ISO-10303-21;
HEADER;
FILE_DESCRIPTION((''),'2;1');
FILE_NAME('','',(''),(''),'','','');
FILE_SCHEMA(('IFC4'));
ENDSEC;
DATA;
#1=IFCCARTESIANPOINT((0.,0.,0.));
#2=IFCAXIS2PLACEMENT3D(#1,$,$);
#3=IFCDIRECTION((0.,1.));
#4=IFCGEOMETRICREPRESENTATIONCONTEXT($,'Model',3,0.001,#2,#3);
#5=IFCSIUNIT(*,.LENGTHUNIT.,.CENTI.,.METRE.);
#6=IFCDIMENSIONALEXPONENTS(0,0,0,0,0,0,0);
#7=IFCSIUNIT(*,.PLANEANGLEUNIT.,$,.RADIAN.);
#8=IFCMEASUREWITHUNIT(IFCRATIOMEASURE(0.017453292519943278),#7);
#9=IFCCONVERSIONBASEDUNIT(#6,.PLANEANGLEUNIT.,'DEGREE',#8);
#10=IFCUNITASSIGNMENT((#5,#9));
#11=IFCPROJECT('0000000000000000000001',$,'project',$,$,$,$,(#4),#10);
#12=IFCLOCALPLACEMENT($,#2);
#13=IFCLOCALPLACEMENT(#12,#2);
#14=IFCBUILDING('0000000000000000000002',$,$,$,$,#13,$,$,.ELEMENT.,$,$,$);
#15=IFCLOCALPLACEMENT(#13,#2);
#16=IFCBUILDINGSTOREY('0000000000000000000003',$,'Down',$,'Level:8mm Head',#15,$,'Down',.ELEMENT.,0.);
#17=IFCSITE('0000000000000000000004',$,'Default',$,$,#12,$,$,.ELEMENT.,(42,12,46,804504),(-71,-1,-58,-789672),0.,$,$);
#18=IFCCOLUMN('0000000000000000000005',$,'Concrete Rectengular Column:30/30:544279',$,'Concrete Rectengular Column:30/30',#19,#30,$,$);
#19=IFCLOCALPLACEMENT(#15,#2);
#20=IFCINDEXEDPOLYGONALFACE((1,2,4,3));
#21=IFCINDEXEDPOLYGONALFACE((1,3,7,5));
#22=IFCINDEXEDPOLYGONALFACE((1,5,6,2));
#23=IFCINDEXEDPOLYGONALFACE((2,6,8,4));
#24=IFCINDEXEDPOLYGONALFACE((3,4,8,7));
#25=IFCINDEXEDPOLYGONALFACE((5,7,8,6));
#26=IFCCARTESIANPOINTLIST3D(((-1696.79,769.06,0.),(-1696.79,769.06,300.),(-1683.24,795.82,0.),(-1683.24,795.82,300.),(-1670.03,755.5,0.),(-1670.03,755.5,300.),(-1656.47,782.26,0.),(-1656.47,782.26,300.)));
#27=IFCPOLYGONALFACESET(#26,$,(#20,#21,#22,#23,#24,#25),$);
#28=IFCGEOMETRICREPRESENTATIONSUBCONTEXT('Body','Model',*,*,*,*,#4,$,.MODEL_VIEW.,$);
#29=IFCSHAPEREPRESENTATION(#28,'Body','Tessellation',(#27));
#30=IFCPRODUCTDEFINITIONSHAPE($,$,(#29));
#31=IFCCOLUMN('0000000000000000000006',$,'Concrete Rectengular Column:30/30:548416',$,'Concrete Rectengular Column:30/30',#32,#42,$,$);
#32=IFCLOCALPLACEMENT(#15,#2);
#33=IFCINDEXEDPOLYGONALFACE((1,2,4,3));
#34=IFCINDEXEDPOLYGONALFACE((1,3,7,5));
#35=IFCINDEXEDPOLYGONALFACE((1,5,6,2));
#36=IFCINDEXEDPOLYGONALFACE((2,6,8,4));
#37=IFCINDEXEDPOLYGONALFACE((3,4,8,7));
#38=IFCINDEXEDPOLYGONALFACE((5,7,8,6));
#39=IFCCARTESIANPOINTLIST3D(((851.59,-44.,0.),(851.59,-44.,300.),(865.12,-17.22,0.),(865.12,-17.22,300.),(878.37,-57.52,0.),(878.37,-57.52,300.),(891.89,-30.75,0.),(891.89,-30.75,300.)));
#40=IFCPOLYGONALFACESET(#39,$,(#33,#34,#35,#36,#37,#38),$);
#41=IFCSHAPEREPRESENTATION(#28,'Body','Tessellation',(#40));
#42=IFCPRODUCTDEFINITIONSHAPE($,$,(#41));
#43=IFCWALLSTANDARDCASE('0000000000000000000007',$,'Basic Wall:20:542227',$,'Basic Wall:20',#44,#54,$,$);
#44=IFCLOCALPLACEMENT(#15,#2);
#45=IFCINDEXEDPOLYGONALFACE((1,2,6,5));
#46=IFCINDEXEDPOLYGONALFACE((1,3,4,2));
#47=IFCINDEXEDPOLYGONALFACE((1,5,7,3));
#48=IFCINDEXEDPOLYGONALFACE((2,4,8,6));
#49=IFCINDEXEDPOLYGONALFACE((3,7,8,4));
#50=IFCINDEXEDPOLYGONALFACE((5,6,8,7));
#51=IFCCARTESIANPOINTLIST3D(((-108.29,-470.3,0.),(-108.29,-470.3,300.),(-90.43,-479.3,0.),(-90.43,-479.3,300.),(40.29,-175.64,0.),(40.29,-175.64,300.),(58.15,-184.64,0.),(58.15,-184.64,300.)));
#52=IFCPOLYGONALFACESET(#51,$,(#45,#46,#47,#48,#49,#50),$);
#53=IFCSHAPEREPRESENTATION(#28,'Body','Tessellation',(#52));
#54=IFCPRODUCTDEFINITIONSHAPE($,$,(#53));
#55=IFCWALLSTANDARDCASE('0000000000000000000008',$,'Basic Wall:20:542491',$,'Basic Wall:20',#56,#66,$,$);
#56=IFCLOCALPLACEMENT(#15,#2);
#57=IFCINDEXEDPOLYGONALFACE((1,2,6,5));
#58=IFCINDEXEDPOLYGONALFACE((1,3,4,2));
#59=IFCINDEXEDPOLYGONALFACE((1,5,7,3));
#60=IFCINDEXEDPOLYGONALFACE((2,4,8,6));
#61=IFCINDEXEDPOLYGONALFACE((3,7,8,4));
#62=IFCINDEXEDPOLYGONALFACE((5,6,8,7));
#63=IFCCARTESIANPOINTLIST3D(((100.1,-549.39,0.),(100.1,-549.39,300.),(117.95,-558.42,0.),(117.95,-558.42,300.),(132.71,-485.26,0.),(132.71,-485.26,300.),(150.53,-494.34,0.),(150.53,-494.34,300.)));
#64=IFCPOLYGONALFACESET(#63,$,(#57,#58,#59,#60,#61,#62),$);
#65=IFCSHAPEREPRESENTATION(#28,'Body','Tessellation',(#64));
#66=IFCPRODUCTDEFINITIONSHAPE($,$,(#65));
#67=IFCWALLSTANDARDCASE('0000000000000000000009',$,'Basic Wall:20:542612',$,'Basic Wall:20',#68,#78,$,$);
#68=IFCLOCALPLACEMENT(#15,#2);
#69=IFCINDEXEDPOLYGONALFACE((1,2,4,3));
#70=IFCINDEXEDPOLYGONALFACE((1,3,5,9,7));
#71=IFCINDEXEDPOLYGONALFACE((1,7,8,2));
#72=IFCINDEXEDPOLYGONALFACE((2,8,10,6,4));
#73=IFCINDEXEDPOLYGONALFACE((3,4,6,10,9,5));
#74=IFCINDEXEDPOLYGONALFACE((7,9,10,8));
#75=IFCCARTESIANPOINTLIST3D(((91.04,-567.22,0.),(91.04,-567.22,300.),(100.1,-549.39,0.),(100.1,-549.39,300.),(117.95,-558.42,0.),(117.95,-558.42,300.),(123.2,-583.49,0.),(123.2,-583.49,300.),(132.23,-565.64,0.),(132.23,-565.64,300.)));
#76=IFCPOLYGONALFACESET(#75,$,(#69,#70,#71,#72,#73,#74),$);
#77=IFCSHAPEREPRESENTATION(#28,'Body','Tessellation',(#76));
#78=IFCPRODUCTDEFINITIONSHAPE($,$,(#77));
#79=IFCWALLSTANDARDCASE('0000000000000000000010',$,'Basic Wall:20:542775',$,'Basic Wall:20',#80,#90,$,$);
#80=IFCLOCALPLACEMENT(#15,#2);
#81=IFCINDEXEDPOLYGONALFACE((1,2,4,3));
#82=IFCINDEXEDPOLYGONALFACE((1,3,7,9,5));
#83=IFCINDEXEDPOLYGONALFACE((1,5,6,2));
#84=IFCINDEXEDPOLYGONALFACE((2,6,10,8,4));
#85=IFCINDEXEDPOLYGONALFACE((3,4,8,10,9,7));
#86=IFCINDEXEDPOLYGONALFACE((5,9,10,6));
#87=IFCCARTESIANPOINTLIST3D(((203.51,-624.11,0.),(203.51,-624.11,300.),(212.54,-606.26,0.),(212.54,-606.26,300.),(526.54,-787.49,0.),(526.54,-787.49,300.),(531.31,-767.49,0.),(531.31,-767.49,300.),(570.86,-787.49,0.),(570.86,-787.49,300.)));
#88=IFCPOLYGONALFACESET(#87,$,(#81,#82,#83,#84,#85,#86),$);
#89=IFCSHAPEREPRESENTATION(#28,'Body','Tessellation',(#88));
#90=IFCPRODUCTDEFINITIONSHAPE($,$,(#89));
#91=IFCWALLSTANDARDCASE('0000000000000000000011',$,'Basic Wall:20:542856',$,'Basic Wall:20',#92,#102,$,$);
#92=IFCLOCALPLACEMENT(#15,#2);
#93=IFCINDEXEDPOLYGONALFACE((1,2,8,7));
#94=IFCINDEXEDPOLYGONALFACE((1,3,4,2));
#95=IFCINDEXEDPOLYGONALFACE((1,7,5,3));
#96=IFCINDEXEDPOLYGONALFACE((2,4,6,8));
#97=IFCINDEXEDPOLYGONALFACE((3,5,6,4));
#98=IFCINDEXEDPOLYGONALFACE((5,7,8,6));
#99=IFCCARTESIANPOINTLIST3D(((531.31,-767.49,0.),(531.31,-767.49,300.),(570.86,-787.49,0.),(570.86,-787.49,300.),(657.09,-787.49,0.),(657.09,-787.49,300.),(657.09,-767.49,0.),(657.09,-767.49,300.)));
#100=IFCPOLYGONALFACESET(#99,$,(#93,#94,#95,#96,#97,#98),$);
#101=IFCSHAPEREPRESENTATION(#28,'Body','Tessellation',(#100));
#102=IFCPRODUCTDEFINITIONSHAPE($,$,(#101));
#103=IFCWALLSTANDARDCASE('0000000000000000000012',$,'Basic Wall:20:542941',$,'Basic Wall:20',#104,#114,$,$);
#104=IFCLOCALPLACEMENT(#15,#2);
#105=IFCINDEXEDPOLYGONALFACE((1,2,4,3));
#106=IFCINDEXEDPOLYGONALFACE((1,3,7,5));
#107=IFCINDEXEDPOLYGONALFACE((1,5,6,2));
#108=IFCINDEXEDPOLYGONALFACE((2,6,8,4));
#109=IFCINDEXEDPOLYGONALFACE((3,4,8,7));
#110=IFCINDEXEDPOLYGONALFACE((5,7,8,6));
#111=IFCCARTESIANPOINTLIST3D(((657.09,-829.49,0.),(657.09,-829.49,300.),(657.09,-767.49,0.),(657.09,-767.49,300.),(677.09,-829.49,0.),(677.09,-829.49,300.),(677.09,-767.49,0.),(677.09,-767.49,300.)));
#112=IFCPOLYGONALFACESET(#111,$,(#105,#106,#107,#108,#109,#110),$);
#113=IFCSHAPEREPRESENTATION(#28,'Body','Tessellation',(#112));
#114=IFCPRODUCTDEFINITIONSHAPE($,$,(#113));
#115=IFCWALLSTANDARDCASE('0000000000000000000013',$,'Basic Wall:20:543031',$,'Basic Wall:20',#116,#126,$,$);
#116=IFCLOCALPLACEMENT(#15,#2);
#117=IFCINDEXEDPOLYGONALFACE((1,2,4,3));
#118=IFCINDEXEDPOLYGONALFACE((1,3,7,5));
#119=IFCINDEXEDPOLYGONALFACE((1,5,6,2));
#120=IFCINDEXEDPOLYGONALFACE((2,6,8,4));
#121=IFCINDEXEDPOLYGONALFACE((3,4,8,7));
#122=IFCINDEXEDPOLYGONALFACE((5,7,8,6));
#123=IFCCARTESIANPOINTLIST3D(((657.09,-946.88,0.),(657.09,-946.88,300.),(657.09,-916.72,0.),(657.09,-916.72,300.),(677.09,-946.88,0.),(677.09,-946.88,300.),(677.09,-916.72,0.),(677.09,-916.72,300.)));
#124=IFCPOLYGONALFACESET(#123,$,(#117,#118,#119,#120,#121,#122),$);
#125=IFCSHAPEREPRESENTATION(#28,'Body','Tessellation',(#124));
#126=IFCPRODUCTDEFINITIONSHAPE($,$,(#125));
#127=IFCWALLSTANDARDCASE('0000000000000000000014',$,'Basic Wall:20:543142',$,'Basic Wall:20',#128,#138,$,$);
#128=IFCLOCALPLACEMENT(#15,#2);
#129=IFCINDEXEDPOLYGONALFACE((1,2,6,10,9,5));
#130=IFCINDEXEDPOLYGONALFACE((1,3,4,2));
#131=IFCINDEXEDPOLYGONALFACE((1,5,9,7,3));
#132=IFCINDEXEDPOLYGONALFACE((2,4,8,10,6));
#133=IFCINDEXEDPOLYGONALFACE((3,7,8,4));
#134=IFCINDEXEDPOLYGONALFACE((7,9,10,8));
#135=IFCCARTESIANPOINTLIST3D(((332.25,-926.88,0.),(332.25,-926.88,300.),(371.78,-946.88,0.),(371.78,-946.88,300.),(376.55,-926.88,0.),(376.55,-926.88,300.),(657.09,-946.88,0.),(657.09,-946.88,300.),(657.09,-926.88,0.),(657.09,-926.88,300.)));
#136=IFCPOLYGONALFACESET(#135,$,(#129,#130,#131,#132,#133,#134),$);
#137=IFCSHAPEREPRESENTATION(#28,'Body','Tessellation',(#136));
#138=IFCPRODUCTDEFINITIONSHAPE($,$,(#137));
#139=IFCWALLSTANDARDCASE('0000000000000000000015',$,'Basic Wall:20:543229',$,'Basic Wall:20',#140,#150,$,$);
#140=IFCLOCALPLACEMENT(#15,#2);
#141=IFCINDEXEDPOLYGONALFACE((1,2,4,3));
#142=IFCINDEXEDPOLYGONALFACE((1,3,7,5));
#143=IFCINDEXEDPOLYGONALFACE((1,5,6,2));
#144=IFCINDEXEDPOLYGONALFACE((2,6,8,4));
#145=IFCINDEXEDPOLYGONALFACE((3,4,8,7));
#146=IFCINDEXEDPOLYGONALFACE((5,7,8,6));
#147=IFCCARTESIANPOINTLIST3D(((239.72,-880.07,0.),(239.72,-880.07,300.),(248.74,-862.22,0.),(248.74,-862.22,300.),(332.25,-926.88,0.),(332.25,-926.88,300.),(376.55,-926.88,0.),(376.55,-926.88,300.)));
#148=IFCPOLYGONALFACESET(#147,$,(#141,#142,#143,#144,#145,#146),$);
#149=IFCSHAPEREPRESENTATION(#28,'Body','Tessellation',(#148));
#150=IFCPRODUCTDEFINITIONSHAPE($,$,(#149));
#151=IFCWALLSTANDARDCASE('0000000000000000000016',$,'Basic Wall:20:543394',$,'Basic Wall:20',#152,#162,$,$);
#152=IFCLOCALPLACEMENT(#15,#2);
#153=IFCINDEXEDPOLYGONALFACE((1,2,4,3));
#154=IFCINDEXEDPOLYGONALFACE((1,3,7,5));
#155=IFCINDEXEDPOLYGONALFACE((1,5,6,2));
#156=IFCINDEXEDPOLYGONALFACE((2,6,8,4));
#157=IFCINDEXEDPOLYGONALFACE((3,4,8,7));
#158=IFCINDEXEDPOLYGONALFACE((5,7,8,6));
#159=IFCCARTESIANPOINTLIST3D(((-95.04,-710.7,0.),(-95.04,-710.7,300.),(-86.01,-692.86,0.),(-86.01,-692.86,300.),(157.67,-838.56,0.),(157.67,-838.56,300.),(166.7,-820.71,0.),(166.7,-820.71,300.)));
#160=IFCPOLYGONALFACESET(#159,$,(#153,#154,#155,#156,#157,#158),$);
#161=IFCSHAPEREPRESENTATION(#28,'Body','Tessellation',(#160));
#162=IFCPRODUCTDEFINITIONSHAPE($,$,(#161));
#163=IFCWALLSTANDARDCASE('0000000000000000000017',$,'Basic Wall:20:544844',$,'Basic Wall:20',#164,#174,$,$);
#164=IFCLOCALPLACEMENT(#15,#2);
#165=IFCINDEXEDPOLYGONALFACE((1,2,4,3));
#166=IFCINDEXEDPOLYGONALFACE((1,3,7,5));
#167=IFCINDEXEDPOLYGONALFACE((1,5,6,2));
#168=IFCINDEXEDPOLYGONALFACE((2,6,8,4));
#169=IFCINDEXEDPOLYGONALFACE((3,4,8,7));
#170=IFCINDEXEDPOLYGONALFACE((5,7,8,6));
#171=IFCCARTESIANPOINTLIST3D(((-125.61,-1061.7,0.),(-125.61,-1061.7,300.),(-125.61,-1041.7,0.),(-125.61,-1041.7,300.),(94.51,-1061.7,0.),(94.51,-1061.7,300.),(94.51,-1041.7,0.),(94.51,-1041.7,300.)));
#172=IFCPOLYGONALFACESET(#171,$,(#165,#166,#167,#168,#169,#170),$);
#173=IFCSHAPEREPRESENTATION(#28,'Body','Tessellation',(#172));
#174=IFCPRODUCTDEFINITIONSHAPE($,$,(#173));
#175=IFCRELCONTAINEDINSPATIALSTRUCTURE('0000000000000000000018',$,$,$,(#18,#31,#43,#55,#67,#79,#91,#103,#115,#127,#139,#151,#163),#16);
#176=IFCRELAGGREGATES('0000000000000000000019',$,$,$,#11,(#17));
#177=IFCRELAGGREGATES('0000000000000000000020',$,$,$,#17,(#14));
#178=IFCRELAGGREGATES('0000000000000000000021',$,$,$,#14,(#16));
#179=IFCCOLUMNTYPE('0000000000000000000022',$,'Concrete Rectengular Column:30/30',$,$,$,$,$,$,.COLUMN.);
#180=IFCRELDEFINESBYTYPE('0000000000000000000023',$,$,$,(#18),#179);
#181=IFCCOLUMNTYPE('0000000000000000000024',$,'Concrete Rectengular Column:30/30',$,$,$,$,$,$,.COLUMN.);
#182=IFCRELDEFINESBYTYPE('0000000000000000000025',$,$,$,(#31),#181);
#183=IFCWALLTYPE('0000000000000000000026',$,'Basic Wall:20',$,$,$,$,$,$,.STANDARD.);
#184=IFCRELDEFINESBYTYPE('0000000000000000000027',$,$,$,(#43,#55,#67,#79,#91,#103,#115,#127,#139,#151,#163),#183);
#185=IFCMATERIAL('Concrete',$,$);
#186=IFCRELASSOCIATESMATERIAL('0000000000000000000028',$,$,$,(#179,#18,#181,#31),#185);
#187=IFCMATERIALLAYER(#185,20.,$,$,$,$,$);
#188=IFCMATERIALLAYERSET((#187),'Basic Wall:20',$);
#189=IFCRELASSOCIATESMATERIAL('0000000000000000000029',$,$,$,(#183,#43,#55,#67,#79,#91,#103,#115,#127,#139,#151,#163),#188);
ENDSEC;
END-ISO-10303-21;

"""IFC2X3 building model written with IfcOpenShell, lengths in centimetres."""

from ifc_helpers import new_model, entity, si_unit, converted_unit, direction, frame, frame_2d, origin, origin_2d_with_axis, place, context, subcontext, project, spatial, polyline, rectangle, outline, extrude, source, transform, mapped, material, layer, layer_set, layer_usage, type_object, type_shapes, element, save


model = new_model("IFC2X3")

# Units and contexts
model_context = context("Model", 3, precision=0.001, world=origin(), true_north=direction((0.0, 1.0)))
body_context = subcontext(model_context, "Body", "Model", "MODEL_VIEW")
ifc_project = project(units=[si_unit("LENGTHUNIT", "METRE", prefix="CENTI"), converted_unit("PLANEANGLEUNIT", "DEGREE", entity("IfcRatioMeasure", 0.017453292519943278), si_unit("PLANEANGLEUNIT", "RADIAN"), dimensions=[0, 0, 0, 0, 0, 0, 0])], contexts=[model_context])

# Site, building, storey
site_placement = place(None, origin())
site = spatial("IfcSite", under=ifc_project, at=site_placement, Name="Default", CompositionType="ELEMENT", RefLatitude=(42, 12, 46, 804504), RefLongitude=(-71, -1, -58, -789672), RefElevation=0.0)
building_placement = place(site_placement, origin())
building = spatial("IfcBuilding", under=site, at=building_placement, CompositionType="ELEMENT")
storey_placement = place(building_placement, origin())
storey = spatial("IfcBuildingStorey", under=building, at=storey_placement, Name="Down", ObjectType="Level:8mm Head", LongName="Down", CompositionType="ELEMENT", Elevation=0.0)

# Columns
ifc_material = material(Name="Concrete")
column_type_1 = type_object("IfcColumnType", Name="Concrete Rectengular Column:30/30", PredefinedType="COLUMN", material=ifc_material)
shared_shape_1 = source(origin(), body_context, "Body", "SweptSolid", [
    extrude(rectangle(XDim=30.0, YDim=30.0, at=origin_2d_with_axis()), frame((-1676.63, 775.66, 0.0), z_axis=(0.0, 0.0, 1.0), x_axis=(0.451903, 0.892067, 0.0)), (0.0, 0.0, 1.0), 300.0),
])
type_shapes(column_type_1, [shared_shape_1])
column_1_placement = place(storey_placement, origin())
element("IfcColumn", 1, at=column_1_placement, inside=storey, type_object=column_type_1, material=ifc_material, Name="Concrete Rectengular Column:30/30:544279", ObjectType="Concrete Rectengular Column:30/30", context=body_context, shape_type="MappedRepresentation", body=[
    mapped(shared_shape_1, transform((0.0, 0.0, 0.0), scale=1.0)),
])
column_type_2 = type_object("IfcColumnType", Name="Concrete Rectengular Column:30/30", PredefinedType="COLUMN", material=ifc_material)
shared_shape_2 = source(origin(), body_context, "Body", "SweptSolid", [
    extrude(rectangle(XDim=30.0, YDim=30.0, at=frame_2d((0.0, 0.0), x_axis=(1.0, 0.0))), frame((871.74, -37.37, 0.0), z_axis=(0.0, 0.0, 1.0), x_axis=(-0.892587, 0.450875, 0.0)), (0.0, 0.0, 1.0), 300.0),
])
type_shapes(column_type_2, [shared_shape_2])
column_2_placement = place(storey_placement, origin())
element("IfcColumn", 2, at=column_2_placement, inside=storey, type_object=column_type_2, material=ifc_material, Name="Concrete Rectengular Column:30/30:548416", ObjectType="Concrete Rectengular Column:30/30", context=body_context, shape_type="MappedRepresentation", body=[
    mapped(shared_shape_2, transform((0.0, 0.0, 0.0), scale=1.0)),
])

# Walls
ifc_layer_1 = layer(ifc_material, 20.0)
ifc_layer_set_1 = layer_set([ifc_layer_1], Name="Basic Wall:20")
ifc_layer_usage_1 = layer_usage(ifc_layer_set_1, "AXIS2", "NEGATIVE", 10.0)
wall_type_1 = type_object("IfcWallType", Name="Basic Wall:20", PredefinedType="STANDARD", material=ifc_layer_set_1)
wall_1_placement = place(storey_placement, frame((49.22, -180.14, 0.0), z_axis=(0.0, 0.0, 1.0), x_axis=(-0.450229, -0.892913, 0.0)))
element("IfcWallStandardCase", 3, at=wall_1_placement, inside=storey, type_object=wall_type_1, material=ifc_layer_usage_1, Name="Basic Wall:20:542227", ObjectType="Basic Wall:20", context=body_context, shape_type="SweptSolid", body=[
    extrude(rectangle(XDim=330.0, YDim=20.0, at=frame_2d((165.0, 0.0), x_axis=(-1.0, 0.0))), origin(), (0.0, 0.0, 1.0), 300.0),
])
ifc_layer_usage_2 = layer_usage(ifc_layer_set_1, "AXIS2", "NEGATIVE", 10.0)
wall_2_placement = place(storey_placement, frame((141.63, -489.8, 0.0), z_axis=(0.0, 0.0, 1.0), x_axis=(-0.453247, -0.891385, 0.0)))
element("IfcWallStandardCase", 4, at=wall_2_placement, inside=storey, type_object=wall_type_1, material=ifc_layer_usage_2, Name="Basic Wall:20:542491", ObjectType="Basic Wall:20", context=body_context, shape_type="SweptSolid", body=[
    extrude(outline(polyline([(71.95, -10.0), (71.9, 10.0), (0.02, 10.0), (0.0, -10.0), (71.95, -10.0)])), origin(), (0.0, 0.0, 1.0), 300.0),
])
ifc_layer_usage_3 = layer_usage(ifc_layer_set_1, "AXIS2", "POSITIVE", -10.0)
wall_3_placement = place(storey_placement, frame((95.55, -558.3, 0.0), z_axis=(0.0, 0.0, 1.0), x_axis=(0.892353, -0.451339, 0.0)))
element("IfcWallStandardCase", 5, at=wall_3_placement, inside=storey, type_object=wall_type_1, material=ifc_layer_usage_3, Name="Basic Wall:20:542612", ObjectType="Basic Wall:20", context=body_context, shape_type="SweptSolid", body=[
    extrude(outline(polyline([(36.04, -10.0), (36.04, 10.0), (20.04, 10.0), (0.04, 10.0), (0.0, -10.0), (36.04, -10.0)])), origin(), (0.0, 0.0, 1.0), 300.0),
])
ifc_layer_usage_4 = layer_usage(ifc_layer_set_1, "AXIS2", "POSITIVE", -10.0)
wall_4_placement = place(storey_placement, frame((208.02, -615.19, 0.0), z_axis=(0.0, 0.0, 1.0), x_axis=(0.892353, -0.451339, 0.0)))
element("IfcWallStandardCase", 6, at=wall_4_placement, inside=storey, type_object=wall_type_1, material=ifc_layer_usage_4, Name="Basic Wall:20:542775", ObjectType="Basic Wall:20", context=body_context, shape_type="SweptSolid", body=[
    extrude(outline(polyline([(362.0, -10.0), (401.54, 10.0), (357.23, 10.0), (0.0, 10.0), (0.0, -10.0), (362.0, -10.0)])), origin(), (0.0, 0.0, 1.0), 300.0),
])
ifc_layer_usage_5 = layer_usage(ifc_layer_set_1, "AXIS2", "POSITIVE", -10.0)
wall_5_placement = place(storey_placement, frame((531.31, -777.49, 0.0)))
element("IfcWallStandardCase", 7, at=wall_5_placement, inside=storey, type_object=wall_type_1, material=ifc_layer_usage_5, Name="Basic Wall:20:542856", ObjectType="Basic Wall:20", context=body_context, shape_type="SweptSolid", body=[
    extrude(outline(polyline([(125.77, -10.0), (125.77, 10.0), (0.0, 10.0), (39.54, -10.0), (125.77, -10.0)])), origin(), (0.0, 0.0, 1.0), 300.0),
])
ifc_layer_usage_6 = layer_usage(ifc_layer_set_1, "AXIS2", "NEGATIVE", 10.0)
wall_6_placement = place(storey_placement, frame((667.09, -767.49, 0.0), z_axis=(0.0, 0.0, 1.0), x_axis=(0.0, -1.0, 0.0)))
element("IfcWallStandardCase", 8, at=wall_6_placement, inside=storey, type_object=wall_type_1, material=ifc_layer_usage_6, Name="Basic Wall:20:542941", ObjectType="Basic Wall:20", context=body_context, shape_type="SweptSolid", body=[
    extrude(rectangle(XDim=62.0, YDim=20.0, at=frame_2d((31.0, 0.0), x_axis=(-1.0, 0.0))), origin(), (0.0, 0.0, 1.0), 300.0),
])
ifc_layer_usage_7 = layer_usage(ifc_layer_set_1, "AXIS2", "NEGATIVE", 10.0)
wall_7_placement = place(storey_placement, frame((667.09, -916.72, 0.0), z_axis=(0.0, 0.0, 1.0), x_axis=(0.0, -1.0, 0.0)))
element("IfcWallStandardCase", 9, at=wall_7_placement, inside=storey, type_object=wall_type_1, material=ifc_layer_usage_7, Name="Basic Wall:20:543031", ObjectType="Basic Wall:20", context=body_context, shape_type="SweptSolid", body=[
    extrude(rectangle(XDim=30.16, YDim=20.0, at=frame_2d((15.08, 0.0), x_axis=(-1.0, 0.0))), origin(), (0.0, 0.0, 1.0), 300.0),
])
ifc_layer_usage_8 = layer_usage(ifc_layer_set_1, "AXIS2", "NEGATIVE", 10.0)
wall_8_placement = place(storey_placement, frame((657.09, -936.88, 0.0), z_axis=(0.0, 0.0, 1.0), x_axis=(-1.0, 0.0, 0.0)))
element("IfcWallStandardCase", 10, at=wall_8_placement, inside=storey, type_object=wall_type_1, material=ifc_layer_usage_8, Name="Basic Wall:20:543142", ObjectType="Basic Wall:20", context=body_context, shape_type="SweptSolid", body=[
    extrude(outline(polyline([(324.84, -10.0), (285.31, 10.0), (0.0, 10.0), (0.0, -10.0), (280.54, -10.0), (324.84, -10.0)])), origin(), (0.0, 0.0, 1.0), 300.0),
])
ifc_layer_usage_9 = layer_usage(ifc_layer_set_1, "AXIS2", "NEGATIVE", 10.0)
wall_9_placement = place(storey_placement, frame((372.03, -935.8, 0.0), z_axis=(0.0, 0.0, 1.0), x_axis=(-0.892301, 0.451441, 0.0)))
element("IfcWallStandardCase", 11, at=wall_9_placement, inside=storey, type_object=wall_type_1, material=ifc_layer_usage_9, Name="Basic Wall:20:543229", ObjectType="Basic Wall:20", context=body_context, shape_type="SweptSolid", body=[
    extrude(outline(polyline([(143.23, -10.0), (143.23, 10.0), (39.53, 10.0), (0.0, -10.0), (143.23, -10.0)])), origin(), (0.0, 0.0, 1.0), 300.0),
])
ifc_layer_usage_10 = layer_usage(ifc_layer_set_1, "AXIS2", "NEGATIVE", 10.0)
wall_10_placement = place(storey_placement, frame((162.18, -829.64, 0.0), z_axis=(0.0, 0.0, 1.0), x_axis=(-0.892301, 0.451441, 0.0)))
element("IfcWallStandardCase", 12, at=wall_10_placement, inside=storey, type_object=wall_type_1, material=ifc_layer_usage_10, Name="Basic Wall:20:543394", ObjectType="Basic Wall:20", context=body_context, shape_type="SweptSolid", body=[
    extrude(rectangle(XDim=283.21, YDim=20.0, at=frame_2d((141.61, 0.0), x_axis=(-1.0, 0.0))), origin(), (0.0, 0.0, 1.0), 300.0),
])
ifc_layer_usage_11 = layer_usage(ifc_layer_set_1, "AXIS2", "POSITIVE", -10.0)
wall_11_placement = place(storey_placement, frame((94.51, -1051.7, 0.0), z_axis=(0.0, 0.0, 1.0), x_axis=(-1.0, 0.0, 0.0)))
element("IfcWallStandardCase", 13, at=wall_11_placement, inside=storey, type_object=wall_type_1, material=ifc_layer_usage_11, Name="Basic Wall:20:544844", ObjectType="Basic Wall:20", context=body_context, shape_type="SweptSolid", body=[
    extrude(rectangle(XDim=220.12, YDim=20.0, at=frame_2d((110.06, 0.0), x_axis=(-1.0, 0.0))), origin(), (0.0, 0.0, 1.0), 300.0),
])

save(model, "model.ifc")
